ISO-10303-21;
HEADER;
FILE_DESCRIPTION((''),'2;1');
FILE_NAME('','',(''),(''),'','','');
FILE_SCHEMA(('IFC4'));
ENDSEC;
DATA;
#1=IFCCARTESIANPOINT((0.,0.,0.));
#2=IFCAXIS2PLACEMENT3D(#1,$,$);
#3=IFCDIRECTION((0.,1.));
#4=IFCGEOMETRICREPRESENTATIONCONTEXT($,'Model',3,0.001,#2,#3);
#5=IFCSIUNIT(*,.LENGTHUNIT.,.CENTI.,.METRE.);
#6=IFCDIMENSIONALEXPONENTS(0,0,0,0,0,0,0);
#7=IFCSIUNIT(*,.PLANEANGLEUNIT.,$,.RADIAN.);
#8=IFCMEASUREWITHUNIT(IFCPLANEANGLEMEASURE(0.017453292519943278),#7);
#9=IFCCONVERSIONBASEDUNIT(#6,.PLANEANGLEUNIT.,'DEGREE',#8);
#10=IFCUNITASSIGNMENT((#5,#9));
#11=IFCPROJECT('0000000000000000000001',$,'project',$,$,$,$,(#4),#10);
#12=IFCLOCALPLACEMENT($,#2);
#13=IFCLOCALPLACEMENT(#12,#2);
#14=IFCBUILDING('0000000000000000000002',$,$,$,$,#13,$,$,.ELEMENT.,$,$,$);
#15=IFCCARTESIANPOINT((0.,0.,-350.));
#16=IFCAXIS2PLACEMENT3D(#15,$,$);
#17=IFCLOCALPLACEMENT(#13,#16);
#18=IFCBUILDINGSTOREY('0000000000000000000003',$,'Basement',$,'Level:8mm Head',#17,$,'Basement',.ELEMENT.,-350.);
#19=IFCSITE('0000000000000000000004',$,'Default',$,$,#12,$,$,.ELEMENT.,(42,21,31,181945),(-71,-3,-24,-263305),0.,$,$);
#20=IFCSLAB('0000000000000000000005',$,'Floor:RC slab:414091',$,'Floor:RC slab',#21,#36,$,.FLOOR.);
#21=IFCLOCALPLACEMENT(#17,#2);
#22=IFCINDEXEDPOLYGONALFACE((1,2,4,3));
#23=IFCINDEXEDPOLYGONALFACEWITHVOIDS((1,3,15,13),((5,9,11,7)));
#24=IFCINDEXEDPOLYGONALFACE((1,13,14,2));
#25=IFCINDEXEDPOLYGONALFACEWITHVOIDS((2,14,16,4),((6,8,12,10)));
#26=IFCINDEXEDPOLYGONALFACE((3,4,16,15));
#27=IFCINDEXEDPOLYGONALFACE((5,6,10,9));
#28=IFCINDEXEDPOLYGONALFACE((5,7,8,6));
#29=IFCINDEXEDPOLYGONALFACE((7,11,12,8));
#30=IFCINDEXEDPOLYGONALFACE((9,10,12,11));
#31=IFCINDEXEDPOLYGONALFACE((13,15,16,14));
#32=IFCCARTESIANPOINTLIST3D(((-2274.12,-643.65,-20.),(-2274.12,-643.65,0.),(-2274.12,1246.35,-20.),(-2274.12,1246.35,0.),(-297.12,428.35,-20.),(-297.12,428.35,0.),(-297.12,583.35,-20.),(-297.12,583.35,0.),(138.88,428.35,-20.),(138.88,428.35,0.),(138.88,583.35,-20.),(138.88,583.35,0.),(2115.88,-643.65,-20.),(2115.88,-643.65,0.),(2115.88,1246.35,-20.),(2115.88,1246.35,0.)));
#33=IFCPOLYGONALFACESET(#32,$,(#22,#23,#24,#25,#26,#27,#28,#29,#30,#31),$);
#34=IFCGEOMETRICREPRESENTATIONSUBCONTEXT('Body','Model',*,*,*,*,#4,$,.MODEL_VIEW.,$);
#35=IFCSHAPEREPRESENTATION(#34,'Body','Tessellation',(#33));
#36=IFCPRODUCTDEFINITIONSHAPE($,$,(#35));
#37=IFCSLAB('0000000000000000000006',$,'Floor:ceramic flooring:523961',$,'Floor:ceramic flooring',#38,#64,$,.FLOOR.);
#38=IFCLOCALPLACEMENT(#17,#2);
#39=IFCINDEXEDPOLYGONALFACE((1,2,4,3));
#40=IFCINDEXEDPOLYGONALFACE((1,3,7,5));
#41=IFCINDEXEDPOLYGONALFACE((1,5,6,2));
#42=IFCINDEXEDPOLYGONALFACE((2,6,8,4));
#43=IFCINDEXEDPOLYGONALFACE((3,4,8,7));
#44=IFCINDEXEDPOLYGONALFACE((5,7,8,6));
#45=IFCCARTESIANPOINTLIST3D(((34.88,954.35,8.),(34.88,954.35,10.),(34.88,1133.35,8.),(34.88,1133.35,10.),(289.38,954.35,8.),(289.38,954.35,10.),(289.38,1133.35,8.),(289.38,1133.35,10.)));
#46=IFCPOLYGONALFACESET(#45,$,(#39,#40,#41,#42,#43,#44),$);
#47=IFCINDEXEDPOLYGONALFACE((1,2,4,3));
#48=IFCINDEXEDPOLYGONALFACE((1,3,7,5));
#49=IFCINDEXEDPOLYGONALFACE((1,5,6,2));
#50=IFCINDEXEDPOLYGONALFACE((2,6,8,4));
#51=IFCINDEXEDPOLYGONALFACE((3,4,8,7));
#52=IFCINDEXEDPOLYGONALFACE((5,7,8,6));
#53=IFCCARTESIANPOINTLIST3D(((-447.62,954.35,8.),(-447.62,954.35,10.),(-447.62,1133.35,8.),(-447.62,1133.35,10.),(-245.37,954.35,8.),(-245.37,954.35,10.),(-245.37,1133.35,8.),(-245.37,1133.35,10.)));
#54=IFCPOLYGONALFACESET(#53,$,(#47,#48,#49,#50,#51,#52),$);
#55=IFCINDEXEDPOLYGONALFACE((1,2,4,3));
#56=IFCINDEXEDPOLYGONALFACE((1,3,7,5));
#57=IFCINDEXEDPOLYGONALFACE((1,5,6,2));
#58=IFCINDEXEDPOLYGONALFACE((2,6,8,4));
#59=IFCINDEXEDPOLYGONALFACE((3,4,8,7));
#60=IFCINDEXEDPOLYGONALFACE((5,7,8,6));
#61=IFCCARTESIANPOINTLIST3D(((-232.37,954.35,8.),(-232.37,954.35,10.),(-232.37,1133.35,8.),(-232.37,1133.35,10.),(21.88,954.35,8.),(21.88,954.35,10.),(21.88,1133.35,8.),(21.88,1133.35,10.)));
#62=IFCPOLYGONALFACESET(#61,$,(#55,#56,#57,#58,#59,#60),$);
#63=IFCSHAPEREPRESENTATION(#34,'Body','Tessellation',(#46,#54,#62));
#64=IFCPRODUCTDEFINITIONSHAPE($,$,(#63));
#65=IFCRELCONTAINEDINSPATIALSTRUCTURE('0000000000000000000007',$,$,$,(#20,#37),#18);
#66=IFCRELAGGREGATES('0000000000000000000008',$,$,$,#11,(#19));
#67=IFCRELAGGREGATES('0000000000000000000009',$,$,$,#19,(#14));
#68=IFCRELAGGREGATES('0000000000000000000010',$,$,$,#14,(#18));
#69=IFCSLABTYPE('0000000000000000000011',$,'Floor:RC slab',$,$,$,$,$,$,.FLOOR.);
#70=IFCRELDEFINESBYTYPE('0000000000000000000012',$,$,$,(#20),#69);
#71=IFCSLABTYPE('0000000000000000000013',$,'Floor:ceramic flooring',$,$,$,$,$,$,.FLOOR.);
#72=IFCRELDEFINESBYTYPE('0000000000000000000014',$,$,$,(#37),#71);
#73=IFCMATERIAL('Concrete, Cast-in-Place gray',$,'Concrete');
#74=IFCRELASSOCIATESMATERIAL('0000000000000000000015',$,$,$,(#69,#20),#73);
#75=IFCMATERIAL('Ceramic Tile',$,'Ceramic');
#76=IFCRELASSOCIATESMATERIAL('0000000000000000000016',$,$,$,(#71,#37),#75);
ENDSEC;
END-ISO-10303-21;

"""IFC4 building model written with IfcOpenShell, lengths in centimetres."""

from ifc_helpers import new_model, entity, si_unit, converted_unit, direction, frame, origin, place, context, subcontext, project, spatial, indexed_curve, outline, extrude, material, type_object, element, save


model = new_model("IFC4")

# Units and contexts
model_context = context("Model", 3, precision=0.001, world=origin(), true_north=direction((0.0, 1.0)))
body_context = subcontext(model_context, "Body", "Model", "MODEL_VIEW")
ifc_project = project(units=[si_unit("LENGTHUNIT", "METRE", prefix="CENTI"), converted_unit("PLANEANGLEUNIT", "DEGREE", entity("IfcPlaneAngleMeasure", 0.017453292519943278), si_unit("PLANEANGLEUNIT", "RADIAN"), dimensions=[0, 0, 0, 0, 0, 0, 0])], contexts=[model_context])

# Site, building, storey
site_placement = place(None, origin())
site = spatial("IfcSite", under=ifc_project, at=site_placement, Name="Default", CompositionType="ELEMENT", RefLatitude=(42, 21, 31, 181945), RefLongitude=(-71, -3, -24, -263305), RefElevation=0.0)
building_placement = place(site_placement, origin())
building = spatial("IfcBuilding", under=site, at=building_placement, CompositionType="ELEMENT")
storey_placement = place(building_placement, frame((0.0, 0.0, -350.0)))
storey = spatial("IfcBuildingStorey", under=building, at=storey_placement, Name="Basement", ObjectType="Level:8mm Head", LongName="Basement", CompositionType="ELEMENT", Elevation=-350.0)

# Slab, opening
ifc_material_1 = material(Name="Concrete, Cast-in-Place gray", Category="Concrete")
slab_type_1 = type_object("IfcSlabType", Name="Floor:RC slab", PredefinedType="FLOOR", material=ifc_material_1)
slab_1_placement = place(storey_placement, origin())
slab_1 = element("IfcSlab", 1, at=slab_1_placement, inside=storey, type_object=slab_type_1, material=ifc_material_1, Name="Floor:RC slab:414091", ObjectType="Floor:RC slab", PredefinedType="FLOOR", context=body_context, shape_type="SweptSolid", body=[
    extrude(outline(indexed_curve([(-2195.0, -945.0), (2195.0, -945.0), (2195.0, 945.0), (-2195.0, 945.0), (-2195.0, -945.0)], self_intersect=False), holes=[indexed_curve([(-218.0, -282.0), (-218.0, -127.0), (218.0, -127.0), (218.0, -282.0), (-218.0, -282.0)], self_intersect=False)]), frame((-79.12, 301.35, -20.0), z_axis=(0.0, 0.0, 1.0), x_axis=(-1.0, 0.0, 0.0)), (0.0, 0.0, 1.0), 20.0),
])
opening_1_placement = place(slab_1_placement, origin())
element("IfcOpeningElement", 2, at=opening_1_placement, cuts=slab_1, PredefinedType="OPENING", context=body_context, shape_type="SweptSolid", body=[
    extrude(outline(indexed_curve([(138.88, 583.35), (-297.12, 583.35), (-297.12, 428.35), (138.88, 428.35), (138.88, 583.35)], self_intersect=False)), frame((0.0, 0.0, 350.0)), (0.0, 0.0, 1.0), 1890.0),
])

# Slab
ifc_material_2 = material(Name="Ceramic Tile", Category="Ceramic")
slab_type_2 = type_object("IfcSlabType", Name="Floor:ceramic flooring", PredefinedType="FLOOR", material=ifc_material_2)
slab_2_placement = place(storey_placement, origin())
element("IfcSlab", 3, at=slab_2_placement, inside=storey, type_object=slab_type_2, material=ifc_material_2, Name="Floor:ceramic flooring:523961", ObjectType="Floor:ceramic flooring", PredefinedType="FLOOR", context=body_context, shape_type="SweptSolid", body=[
    extrude(outline(indexed_curve([(-127.25, -89.5), (127.25, -89.5), (127.25, 89.5), (-127.25, 89.5), (-127.25, -89.5)], self_intersect=False)), frame((162.13, 1043.85, 8.0), z_axis=(0.0, 0.0, 1.0), x_axis=(-1.0, 0.0, 0.0)), (0.0, 0.0, 1.0), 2.0),
    extrude(outline(indexed_curve([(-101.12, -89.5), (101.12, -89.5), (101.12, 89.5), (-101.12, 89.5), (-101.12, -89.5)], self_intersect=False)), frame((-346.5, 1043.85, 8.0), z_axis=(0.0, 0.0, 1.0), x_axis=(-1.0, 0.0, 0.0)), (0.0, 0.0, 1.0), 2.0),
    extrude(outline(indexed_curve([(-127.13, -89.5), (127.13, -89.5), (127.13, 89.5), (-127.13, 89.5), (-127.13, -89.5)], self_intersect=False)), frame((-105.25, 1043.85, 8.0), z_axis=(0.0, 0.0, 1.0), x_axis=(-1.0, 0.0, 0.0)), (0.0, 0.0, 1.0), 2.0),
])

save(model, "model.ifc")
